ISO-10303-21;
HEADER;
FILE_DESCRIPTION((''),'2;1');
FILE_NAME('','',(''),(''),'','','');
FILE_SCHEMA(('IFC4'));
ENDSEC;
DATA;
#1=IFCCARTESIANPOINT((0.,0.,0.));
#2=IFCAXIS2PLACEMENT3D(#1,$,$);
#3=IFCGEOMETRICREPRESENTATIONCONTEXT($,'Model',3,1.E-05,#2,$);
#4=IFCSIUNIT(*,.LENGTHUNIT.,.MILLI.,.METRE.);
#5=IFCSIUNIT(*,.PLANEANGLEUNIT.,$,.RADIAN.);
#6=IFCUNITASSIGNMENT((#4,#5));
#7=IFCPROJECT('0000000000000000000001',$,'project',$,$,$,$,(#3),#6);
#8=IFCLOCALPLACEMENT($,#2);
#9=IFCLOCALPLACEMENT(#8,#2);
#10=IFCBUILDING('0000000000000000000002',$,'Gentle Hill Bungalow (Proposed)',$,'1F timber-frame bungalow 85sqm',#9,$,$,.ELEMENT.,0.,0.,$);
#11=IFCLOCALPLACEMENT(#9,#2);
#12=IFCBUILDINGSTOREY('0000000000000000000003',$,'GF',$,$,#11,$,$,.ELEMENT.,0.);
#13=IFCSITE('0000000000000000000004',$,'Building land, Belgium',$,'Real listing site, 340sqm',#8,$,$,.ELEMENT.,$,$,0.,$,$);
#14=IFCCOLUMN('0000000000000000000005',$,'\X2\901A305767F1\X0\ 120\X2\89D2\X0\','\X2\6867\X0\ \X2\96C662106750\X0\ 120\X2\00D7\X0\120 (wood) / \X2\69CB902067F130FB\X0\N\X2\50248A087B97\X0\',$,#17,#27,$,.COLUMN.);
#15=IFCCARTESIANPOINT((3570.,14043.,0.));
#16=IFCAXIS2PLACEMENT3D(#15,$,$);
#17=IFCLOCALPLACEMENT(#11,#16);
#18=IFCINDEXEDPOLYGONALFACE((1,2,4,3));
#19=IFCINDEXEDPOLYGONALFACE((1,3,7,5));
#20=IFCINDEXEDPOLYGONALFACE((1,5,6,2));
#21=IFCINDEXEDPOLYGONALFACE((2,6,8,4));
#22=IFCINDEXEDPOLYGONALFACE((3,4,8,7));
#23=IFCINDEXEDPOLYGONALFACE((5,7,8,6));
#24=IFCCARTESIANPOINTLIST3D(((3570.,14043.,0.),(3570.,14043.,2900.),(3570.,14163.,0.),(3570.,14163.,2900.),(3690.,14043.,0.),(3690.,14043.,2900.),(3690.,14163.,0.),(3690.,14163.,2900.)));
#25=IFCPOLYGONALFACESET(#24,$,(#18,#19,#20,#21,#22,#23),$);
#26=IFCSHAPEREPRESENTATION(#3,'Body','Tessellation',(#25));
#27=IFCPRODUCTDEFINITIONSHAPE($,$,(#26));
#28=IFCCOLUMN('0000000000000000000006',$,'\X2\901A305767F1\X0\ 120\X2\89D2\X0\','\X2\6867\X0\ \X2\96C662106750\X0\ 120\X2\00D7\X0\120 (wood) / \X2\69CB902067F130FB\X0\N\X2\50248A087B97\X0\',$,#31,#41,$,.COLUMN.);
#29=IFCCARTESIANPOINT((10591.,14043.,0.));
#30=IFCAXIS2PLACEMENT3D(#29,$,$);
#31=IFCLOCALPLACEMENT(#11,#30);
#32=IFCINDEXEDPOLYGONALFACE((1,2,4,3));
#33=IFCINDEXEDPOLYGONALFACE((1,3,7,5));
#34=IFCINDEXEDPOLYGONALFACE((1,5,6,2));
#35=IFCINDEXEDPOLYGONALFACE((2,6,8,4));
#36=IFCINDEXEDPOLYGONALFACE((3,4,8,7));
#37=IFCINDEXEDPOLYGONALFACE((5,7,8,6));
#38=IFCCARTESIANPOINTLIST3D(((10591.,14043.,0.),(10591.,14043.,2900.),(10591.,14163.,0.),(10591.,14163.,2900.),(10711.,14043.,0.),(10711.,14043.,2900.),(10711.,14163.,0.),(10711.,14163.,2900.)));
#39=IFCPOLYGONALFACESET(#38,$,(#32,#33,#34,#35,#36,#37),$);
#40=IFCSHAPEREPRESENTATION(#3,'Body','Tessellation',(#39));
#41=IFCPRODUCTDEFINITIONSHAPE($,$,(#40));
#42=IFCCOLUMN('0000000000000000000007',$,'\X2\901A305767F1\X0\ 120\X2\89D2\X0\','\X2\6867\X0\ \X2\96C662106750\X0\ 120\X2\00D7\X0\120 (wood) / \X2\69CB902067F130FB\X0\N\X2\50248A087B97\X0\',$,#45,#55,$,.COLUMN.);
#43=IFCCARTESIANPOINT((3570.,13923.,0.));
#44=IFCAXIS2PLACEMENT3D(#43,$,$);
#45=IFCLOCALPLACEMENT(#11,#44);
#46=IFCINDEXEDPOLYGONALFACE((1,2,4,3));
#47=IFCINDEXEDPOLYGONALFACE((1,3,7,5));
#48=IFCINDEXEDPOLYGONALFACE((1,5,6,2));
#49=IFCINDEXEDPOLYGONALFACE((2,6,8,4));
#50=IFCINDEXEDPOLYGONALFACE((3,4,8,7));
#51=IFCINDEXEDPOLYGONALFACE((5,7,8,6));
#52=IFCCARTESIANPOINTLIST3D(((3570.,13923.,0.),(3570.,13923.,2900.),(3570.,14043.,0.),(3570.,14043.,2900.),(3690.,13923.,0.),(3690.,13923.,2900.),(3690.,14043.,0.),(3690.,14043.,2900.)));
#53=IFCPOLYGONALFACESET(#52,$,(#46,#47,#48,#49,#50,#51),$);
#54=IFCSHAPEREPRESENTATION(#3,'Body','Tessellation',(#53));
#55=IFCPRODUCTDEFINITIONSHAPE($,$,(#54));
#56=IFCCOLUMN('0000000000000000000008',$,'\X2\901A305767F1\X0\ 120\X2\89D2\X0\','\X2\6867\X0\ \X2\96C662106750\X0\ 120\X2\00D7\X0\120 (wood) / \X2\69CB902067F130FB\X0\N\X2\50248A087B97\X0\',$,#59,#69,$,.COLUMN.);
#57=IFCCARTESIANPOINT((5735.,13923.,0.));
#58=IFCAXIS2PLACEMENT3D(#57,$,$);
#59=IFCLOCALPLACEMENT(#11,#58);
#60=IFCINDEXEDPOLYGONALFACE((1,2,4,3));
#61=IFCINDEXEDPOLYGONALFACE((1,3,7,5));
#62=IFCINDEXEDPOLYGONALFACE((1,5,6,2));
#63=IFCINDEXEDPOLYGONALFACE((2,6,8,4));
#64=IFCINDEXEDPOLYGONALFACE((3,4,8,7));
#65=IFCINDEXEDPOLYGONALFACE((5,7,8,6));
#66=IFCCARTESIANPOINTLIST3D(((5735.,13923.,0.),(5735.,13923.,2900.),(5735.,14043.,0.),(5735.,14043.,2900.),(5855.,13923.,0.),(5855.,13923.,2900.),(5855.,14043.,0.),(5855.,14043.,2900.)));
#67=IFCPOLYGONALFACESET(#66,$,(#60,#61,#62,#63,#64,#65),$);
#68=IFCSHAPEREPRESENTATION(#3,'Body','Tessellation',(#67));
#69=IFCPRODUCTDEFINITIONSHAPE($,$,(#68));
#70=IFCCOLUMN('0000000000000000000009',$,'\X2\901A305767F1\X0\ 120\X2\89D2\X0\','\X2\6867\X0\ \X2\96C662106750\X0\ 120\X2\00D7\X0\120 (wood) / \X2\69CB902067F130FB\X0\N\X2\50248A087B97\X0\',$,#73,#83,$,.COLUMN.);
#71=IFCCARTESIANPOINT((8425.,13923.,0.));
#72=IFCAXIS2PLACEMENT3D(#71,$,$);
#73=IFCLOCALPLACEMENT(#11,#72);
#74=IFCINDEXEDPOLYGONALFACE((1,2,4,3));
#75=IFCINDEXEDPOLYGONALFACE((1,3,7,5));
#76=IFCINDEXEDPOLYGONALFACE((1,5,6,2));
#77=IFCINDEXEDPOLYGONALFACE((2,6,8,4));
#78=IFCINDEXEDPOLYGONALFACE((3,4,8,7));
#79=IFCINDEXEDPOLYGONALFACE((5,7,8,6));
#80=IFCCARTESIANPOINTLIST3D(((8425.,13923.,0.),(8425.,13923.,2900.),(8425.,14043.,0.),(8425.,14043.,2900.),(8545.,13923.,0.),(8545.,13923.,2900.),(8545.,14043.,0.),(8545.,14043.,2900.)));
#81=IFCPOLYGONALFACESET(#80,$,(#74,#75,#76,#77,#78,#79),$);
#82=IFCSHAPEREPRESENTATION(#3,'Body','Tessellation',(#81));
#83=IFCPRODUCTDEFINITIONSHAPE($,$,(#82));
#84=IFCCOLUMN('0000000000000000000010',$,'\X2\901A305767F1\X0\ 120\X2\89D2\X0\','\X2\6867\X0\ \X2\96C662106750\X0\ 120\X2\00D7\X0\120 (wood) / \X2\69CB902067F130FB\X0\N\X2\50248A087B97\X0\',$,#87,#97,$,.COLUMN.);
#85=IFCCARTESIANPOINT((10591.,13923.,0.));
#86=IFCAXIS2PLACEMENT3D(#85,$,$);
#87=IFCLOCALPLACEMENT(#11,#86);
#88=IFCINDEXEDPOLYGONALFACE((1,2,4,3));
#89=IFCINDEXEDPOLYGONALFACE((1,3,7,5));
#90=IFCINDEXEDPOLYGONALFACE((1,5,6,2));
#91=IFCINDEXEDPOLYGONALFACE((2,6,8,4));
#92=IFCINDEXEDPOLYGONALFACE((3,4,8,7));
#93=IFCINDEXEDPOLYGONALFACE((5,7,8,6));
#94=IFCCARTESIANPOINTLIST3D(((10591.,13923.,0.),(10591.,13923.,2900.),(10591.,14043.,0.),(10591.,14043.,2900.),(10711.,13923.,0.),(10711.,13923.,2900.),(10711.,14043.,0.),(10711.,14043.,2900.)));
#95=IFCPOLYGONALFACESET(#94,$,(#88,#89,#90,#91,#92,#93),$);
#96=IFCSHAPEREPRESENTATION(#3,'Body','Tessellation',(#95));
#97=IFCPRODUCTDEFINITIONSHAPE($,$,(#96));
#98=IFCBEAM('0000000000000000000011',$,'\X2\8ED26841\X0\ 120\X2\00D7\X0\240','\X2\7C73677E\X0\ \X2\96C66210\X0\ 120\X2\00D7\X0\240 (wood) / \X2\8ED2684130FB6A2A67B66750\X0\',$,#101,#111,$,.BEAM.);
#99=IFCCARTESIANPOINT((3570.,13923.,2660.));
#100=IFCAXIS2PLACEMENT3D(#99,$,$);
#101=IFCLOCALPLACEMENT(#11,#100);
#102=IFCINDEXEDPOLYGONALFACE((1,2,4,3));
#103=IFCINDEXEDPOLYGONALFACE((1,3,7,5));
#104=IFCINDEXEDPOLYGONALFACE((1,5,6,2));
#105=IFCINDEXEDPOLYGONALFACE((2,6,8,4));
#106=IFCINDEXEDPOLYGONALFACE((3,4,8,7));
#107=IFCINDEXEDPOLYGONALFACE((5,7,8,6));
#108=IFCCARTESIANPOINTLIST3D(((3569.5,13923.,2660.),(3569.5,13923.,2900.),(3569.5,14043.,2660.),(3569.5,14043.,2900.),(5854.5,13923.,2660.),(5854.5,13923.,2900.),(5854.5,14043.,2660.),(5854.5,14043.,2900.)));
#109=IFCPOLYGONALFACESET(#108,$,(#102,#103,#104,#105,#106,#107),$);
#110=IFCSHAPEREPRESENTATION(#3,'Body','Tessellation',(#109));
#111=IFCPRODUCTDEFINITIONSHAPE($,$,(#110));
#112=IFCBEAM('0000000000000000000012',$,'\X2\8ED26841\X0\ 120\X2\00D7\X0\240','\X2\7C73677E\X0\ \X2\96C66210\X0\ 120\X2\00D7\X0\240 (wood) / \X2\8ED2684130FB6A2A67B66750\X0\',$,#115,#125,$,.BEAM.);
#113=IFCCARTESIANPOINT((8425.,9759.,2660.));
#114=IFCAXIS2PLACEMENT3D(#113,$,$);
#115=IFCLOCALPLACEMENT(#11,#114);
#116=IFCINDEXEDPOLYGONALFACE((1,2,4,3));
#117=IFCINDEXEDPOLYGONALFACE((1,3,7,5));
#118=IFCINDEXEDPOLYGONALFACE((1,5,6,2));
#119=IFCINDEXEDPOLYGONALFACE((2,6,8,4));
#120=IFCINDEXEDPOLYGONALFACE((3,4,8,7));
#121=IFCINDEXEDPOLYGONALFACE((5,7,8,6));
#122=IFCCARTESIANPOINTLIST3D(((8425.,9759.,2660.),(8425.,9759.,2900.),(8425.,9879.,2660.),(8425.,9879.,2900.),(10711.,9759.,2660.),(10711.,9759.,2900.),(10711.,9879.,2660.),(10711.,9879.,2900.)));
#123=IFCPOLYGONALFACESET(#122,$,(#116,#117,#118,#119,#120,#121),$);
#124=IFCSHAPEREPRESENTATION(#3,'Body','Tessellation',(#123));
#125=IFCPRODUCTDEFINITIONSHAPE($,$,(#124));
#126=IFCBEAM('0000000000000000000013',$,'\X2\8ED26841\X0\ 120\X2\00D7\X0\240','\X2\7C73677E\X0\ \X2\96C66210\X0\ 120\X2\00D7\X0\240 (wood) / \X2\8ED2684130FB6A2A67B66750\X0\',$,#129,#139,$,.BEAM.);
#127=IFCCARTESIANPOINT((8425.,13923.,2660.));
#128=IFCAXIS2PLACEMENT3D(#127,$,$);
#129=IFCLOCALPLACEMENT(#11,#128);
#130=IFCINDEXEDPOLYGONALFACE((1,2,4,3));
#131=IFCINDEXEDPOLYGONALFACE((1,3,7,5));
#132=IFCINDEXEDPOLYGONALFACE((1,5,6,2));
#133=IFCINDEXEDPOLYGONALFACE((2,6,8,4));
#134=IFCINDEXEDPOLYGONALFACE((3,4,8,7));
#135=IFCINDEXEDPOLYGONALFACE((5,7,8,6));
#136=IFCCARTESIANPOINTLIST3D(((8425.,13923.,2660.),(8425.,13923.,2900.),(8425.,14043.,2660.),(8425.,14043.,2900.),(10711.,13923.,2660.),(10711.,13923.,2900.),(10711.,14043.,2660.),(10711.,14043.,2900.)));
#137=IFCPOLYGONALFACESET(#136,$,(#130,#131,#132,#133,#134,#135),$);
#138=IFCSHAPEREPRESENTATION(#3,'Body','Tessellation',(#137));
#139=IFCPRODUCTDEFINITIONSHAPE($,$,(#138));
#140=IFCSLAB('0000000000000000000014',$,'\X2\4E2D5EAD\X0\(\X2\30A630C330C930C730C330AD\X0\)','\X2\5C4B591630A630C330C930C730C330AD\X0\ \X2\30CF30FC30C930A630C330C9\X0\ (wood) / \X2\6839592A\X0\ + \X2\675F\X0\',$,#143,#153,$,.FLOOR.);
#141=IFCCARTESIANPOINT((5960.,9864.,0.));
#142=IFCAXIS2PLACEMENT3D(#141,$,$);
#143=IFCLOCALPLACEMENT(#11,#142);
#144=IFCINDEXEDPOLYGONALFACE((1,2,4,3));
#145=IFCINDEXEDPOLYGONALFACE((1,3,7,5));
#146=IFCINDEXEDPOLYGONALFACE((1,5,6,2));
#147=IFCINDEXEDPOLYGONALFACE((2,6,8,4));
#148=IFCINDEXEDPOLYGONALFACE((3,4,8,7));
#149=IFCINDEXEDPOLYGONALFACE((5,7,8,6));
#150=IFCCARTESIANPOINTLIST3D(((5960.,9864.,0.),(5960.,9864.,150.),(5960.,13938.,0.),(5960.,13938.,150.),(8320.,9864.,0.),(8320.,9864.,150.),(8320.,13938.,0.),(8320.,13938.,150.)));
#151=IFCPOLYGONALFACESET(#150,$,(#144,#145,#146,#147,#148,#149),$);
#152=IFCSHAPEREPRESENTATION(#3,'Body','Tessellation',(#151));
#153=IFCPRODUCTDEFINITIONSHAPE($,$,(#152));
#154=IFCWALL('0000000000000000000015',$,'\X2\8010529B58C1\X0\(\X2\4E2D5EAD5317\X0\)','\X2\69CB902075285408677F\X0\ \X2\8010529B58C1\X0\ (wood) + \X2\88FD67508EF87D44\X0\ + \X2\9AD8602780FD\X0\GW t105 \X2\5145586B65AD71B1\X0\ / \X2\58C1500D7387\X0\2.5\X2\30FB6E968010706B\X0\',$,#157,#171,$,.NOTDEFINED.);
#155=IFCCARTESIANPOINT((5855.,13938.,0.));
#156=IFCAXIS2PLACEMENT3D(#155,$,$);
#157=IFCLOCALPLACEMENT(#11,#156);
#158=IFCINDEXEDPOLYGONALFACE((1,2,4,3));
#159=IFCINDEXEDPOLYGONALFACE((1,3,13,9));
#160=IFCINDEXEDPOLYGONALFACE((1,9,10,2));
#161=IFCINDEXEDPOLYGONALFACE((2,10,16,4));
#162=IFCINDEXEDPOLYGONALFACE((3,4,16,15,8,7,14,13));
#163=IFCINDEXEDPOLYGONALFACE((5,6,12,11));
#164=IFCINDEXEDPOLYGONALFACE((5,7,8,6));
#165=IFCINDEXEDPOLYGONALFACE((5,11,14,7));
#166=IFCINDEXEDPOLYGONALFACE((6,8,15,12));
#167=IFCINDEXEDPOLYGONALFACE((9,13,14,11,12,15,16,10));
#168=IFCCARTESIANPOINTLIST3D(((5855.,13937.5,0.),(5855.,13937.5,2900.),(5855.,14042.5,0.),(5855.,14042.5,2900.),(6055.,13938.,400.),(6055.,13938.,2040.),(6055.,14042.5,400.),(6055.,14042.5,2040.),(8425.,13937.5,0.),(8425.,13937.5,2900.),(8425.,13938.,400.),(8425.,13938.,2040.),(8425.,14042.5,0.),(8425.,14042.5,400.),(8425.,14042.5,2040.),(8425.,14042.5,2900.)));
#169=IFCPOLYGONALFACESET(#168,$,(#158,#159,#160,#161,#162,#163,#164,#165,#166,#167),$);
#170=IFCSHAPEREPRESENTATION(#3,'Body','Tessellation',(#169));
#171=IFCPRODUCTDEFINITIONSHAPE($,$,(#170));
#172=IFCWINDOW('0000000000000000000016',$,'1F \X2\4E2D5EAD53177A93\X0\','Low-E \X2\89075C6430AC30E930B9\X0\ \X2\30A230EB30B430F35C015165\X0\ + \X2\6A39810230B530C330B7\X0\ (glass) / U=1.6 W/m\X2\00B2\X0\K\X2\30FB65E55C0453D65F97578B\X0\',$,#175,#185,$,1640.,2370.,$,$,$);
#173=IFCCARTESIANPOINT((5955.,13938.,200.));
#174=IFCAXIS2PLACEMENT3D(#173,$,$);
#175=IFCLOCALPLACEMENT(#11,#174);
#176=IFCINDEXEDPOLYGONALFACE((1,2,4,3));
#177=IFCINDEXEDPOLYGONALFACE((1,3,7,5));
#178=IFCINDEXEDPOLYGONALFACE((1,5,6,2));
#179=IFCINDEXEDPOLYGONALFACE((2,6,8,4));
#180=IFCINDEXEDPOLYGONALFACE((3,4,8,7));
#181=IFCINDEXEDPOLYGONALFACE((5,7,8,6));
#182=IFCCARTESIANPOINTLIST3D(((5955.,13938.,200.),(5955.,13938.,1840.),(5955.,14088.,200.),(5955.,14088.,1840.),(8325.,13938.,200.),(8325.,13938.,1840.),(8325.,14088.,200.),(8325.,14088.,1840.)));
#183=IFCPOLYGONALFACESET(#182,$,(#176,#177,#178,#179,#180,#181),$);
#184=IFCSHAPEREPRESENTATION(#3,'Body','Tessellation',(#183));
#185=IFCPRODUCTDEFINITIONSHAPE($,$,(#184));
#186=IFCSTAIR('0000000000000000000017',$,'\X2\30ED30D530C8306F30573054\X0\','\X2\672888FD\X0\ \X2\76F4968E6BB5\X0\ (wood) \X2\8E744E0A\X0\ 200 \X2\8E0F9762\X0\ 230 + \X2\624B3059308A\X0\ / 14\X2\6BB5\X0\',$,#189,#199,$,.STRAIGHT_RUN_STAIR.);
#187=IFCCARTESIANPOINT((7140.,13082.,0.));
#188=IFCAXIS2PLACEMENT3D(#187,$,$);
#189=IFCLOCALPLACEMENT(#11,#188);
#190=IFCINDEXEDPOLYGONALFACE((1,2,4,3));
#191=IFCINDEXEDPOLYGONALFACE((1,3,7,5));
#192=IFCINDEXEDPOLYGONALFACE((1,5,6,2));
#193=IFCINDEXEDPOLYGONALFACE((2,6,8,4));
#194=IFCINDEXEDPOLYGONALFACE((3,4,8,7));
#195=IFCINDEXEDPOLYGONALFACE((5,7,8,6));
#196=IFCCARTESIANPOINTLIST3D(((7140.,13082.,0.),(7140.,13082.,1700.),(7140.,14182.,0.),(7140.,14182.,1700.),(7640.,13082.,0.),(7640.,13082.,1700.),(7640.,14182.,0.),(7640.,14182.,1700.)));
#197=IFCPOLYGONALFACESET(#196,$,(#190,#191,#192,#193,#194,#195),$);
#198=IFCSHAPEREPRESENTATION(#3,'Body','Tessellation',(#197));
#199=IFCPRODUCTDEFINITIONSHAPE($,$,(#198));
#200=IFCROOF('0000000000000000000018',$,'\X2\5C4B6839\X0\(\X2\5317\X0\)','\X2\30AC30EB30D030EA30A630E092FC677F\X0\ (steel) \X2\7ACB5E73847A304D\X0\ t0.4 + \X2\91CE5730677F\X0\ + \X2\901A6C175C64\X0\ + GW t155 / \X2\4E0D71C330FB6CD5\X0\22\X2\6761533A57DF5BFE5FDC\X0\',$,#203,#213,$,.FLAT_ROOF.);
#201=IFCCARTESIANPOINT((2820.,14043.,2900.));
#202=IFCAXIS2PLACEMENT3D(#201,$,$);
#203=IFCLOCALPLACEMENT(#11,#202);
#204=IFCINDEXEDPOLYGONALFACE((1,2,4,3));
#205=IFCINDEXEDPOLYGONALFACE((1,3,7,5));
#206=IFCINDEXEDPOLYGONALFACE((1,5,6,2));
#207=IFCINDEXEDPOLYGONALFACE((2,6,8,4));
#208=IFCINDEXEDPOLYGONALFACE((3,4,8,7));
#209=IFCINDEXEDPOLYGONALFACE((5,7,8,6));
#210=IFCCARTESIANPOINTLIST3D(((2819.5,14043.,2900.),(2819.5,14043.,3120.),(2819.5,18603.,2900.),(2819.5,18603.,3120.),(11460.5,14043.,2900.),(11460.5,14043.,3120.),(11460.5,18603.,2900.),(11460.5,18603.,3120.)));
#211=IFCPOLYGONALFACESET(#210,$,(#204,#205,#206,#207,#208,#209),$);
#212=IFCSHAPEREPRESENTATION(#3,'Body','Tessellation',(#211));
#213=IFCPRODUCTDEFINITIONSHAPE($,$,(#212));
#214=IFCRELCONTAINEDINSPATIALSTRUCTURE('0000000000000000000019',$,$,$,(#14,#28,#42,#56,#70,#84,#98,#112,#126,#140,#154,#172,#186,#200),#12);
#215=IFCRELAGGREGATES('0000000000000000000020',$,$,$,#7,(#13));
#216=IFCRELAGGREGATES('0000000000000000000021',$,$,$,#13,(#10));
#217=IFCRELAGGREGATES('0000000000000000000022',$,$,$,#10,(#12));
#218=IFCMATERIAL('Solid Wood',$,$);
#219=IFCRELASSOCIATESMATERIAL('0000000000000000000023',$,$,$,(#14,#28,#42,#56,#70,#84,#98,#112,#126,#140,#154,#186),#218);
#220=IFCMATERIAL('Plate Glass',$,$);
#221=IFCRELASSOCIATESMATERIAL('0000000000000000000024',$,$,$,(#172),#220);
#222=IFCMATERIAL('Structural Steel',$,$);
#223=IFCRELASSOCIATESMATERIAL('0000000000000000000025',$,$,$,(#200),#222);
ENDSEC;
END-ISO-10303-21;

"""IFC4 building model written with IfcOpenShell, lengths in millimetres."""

from ifc_helpers import new_model, si_unit, frame, frame_2d, origin, place, context, project, spatial, rectangle, extrude, material, element, fill, save


model = new_model("IFC4")

# Units and contexts
model_context = context("Model", 3, precision=1e-05, world=origin())
ifc_project = project(units=[si_unit("LENGTHUNIT", "METRE", prefix="MILLI"), si_unit("PLANEANGLEUNIT", "RADIAN")], contexts=[model_context])

# Site, building, storey
site_placement = place(None, origin())
site = spatial("IfcSite", under=ifc_project, at=site_placement, Name="Building land, Belgium", ObjectType="Real listing site, 340sqm", CompositionType="ELEMENT", RefElevation=0.0)
building_placement = place(site_placement, origin())
building = spatial("IfcBuilding", under=site, at=building_placement, Name="Gentle Hill Bungalow (Proposed)", ObjectType="1F timber-frame bungalow 85sqm", CompositionType="ELEMENT", ElevationOfRefHeight=0.0, ElevationOfTerrain=0.0)
storey_placement = place(building_placement, origin())
storey = spatial("IfcBuildingStorey", under=building, at=storey_placement, Name="GF", CompositionType="ELEMENT", Elevation=0.0)

# Columns
ifc_material_1 = material(Name="Solid Wood")
column_1_placement = place(storey_placement, frame((3570.0, 14043.0, 0.0)))
element("IfcColumn", 1, at=column_1_placement, inside=storey, material=ifc_material_1, Name="通し柱 120角", Description="桧 集成材 120×120 (wood) / 構造柱・N値計算", PredefinedType="COLUMN", context=model_context, shape_type="SweptSolid", body=[
    extrude(rectangle(XDim=120.0, YDim=120.0, at=frame_2d((60.0, 60.0))), frame((3570.0, 14043.0, 0.0)), (0.0, 0.0, 1.0), 2900.0),
])
column_2_placement = place(storey_placement, frame((10591.0, 14043.0, 0.0)))
element("IfcColumn", 2, at=column_2_placement, inside=storey, material=ifc_material_1, Name="通し柱 120角", Description="桧 集成材 120×120 (wood) / 構造柱・N値計算", PredefinedType="COLUMN", context=model_context, shape_type="SweptSolid", body=[
    extrude(rectangle(XDim=120.0, YDim=120.0, at=frame_2d((60.0, 60.0))), frame((10591.0, 14043.0, 0.0)), (0.0, 0.0, 1.0), 2900.0),
])
column_3_placement = place(storey_placement, frame((3570.0, 13923.0, 0.0)))
element("IfcColumn", 3, at=column_3_placement, inside=storey, material=ifc_material_1, Name="通し柱 120角", Description="桧 集成材 120×120 (wood) / 構造柱・N値計算", PredefinedType="COLUMN", context=model_context, shape_type="SweptSolid", body=[
    extrude(rectangle(XDim=120.0, YDim=120.0, at=frame_2d((60.0, 60.0))), frame((3570.0, 13923.0, 0.0)), (0.0, 0.0, 1.0), 2900.0),
])
column_4_placement = place(storey_placement, frame((5735.0, 13923.0, 0.0)))
element("IfcColumn", 4, at=column_4_placement, inside=storey, material=ifc_material_1, Name="通し柱 120角", Description="桧 集成材 120×120 (wood) / 構造柱・N値計算", PredefinedType="COLUMN", context=model_context, shape_type="SweptSolid", body=[
    extrude(rectangle(XDim=120.0, YDim=120.0, at=frame_2d((60.0, 60.0))), frame((5735.0, 13923.0, 0.0)), (0.0, 0.0, 1.0), 2900.0),
])
column_5_placement = place(storey_placement, frame((8425.0, 13923.0, 0.0)))
element("IfcColumn", 5, at=column_5_placement, inside=storey, material=ifc_material_1, Name="通し柱 120角", Description="桧 集成材 120×120 (wood) / 構造柱・N値計算", PredefinedType="COLUMN", context=model_context, shape_type="SweptSolid", body=[
    extrude(rectangle(XDim=120.0, YDim=120.0, at=frame_2d((60.0, 60.0))), frame((8425.0, 13923.0, 0.0)), (0.0, 0.0, 1.0), 2900.0),
])
column_6_placement = place(storey_placement, frame((10591.0, 13923.0, 0.0)))
element("IfcColumn", 6, at=column_6_placement, inside=storey, material=ifc_material_1, Name="通し柱 120角", Description="桧 集成材 120×120 (wood) / 構造柱・N値計算", PredefinedType="COLUMN", context=model_context, shape_type="SweptSolid", body=[
    extrude(rectangle(XDim=120.0, YDim=120.0, at=frame_2d((60.0, 60.0))), frame((10591.0, 13923.0, 0.0)), (0.0, 0.0, 1.0), 2900.0),
])

# Beams
beam_1_placement = place(storey_placement, frame((3570.0, 13923.0, 2660.0)))
element("IfcBeam", 7, at=beam_1_placement, inside=storey, material=ifc_material_1, Name="軒桁 120×240", Description="米松 集成 120×240 (wood) / 軒桁・横架材", PredefinedType="BEAM", context=model_context, shape_type="SweptSolid", body=[
    extrude(rectangle(XDim=2285.0, YDim=120.0, at=frame_2d((1142.0, 60.0))), frame((3570.0, 13923.0, 2660.0)), (0.0, 0.0, 1.0), 240.0),
])
beam_2_placement = place(storey_placement, frame((8425.0, 9759.0, 2660.0)))
element("IfcBeam", 8, at=beam_2_placement, inside=storey, material=ifc_material_1, Name="軒桁 120×240", Description="米松 集成 120×240 (wood) / 軒桁・横架材", PredefinedType="BEAM", context=model_context, shape_type="SweptSolid", body=[
    extrude(rectangle(XDim=2286.0, YDim=120.0, at=frame_2d((1143.0, 60.0))), frame((8425.0, 9759.0, 2660.0)), (0.0, 0.0, 1.0), 240.0),
])
beam_3_placement = place(storey_placement, frame((8425.0, 13923.0, 2660.0)))
element("IfcBeam", 9, at=beam_3_placement, inside=storey, material=ifc_material_1, Name="軒桁 120×240", Description="米松 集成 120×240 (wood) / 軒桁・横架材", PredefinedType="BEAM", context=model_context, shape_type="SweptSolid", body=[
    extrude(rectangle(XDim=2286.0, YDim=120.0, at=frame_2d((1143.0, 60.0))), frame((8425.0, 13923.0, 2660.0)), (0.0, 0.0, 1.0), 240.0),
])

# Slab
slab_1_placement = place(storey_placement, frame((5960.0, 9864.0, 0.0)))
element("IfcSlab", 10, at=slab_1_placement, inside=storey, material=ifc_material_1, Name="中庭(ウッドデッキ)", Description="屋外ウッドデッキ ハードウッド (wood) / 根太 + 束", PredefinedType="FLOOR", context=model_context, shape_type="SweptSolid", body=[
    extrude(rectangle(XDim=2360.0, YDim=4074.0, at=frame_2d((1180.0, 2037.0))), frame((5960.0, 9864.0, 0.0)), (0.0, 0.0, 1.0), 150.0),
])

# Wall, opening, window
wall_placement = place(storey_placement, frame((5855.0, 13938.0, 0.0)))
wall = element("IfcWall", 11, at=wall_placement, inside=storey, material=ifc_material_1, Name="耐力壁(中庭北)", Description="構造用合板 耐力壁 (wood) + 製材軸組 + 高性能GW t105 充填断熱 / 壁倍率2.5・準耐火", PredefinedType="NOTDEFINED", context=model_context, shape_type="SweptSolid", body=[
    extrude(rectangle(XDim=2570.0, YDim=105.0, at=frame_2d((1285.0, 52.0))), frame((5855.0, 13938.0, 0.0)), (0.0, 0.0, 1.0), 2900.0),
])
opening_placement = place(storey_placement, frame((5955.0, 13938.0, 200.0)))
opening = element("IfcOpeningElement", 12, at=opening_placement, cuts=wall, PredefinedType="NOTDEFINED", context=model_context, shape_type="SweptSolid", body=[
    extrude(rectangle(XDim=2370.0, YDim=150.0, at=frame_2d((1185.0, 75.0))), frame((5955.0, 13938.0, 200.0)), (0.0, 0.0, 1.0), 1640.0),
])
ifc_material_2 = material(Name="Plate Glass")
window_placement = place(storey_placement, frame((5955.0, 13938.0, 200.0)))
window = element("IfcWindow", 13, at=window_placement, inside=storey, material=ifc_material_2, Name="1F 中庭北窓", Description="Low-E 複層ガラス アルゴン封入 + 樹脂サッシ (glass) / U=1.6 W/m²K・日射取得型", OverallHeight=1640.0, OverallWidth=2370.0, context=model_context, shape_type="SweptSolid", body=[
    extrude(rectangle(XDim=2370.0, YDim=150.0, at=frame_2d((1185.0, 75.0))), frame((5955.0, 13938.0, 200.0)), (0.0, 0.0, 1.0), 1640.0),
])
fill(opening, window)

# Stair
stair_placement = place(storey_placement, frame((7140.0, 13082.0, 0.0)))
element("IfcStair", 14, at=stair_placement, inside=storey, material=ifc_material_1, Name="ロフトはしご", Description="木製 直階段 (wood) 蹴上 200 踏面 230 + 手すり / 14段", PredefinedType="STRAIGHT_RUN_STAIR", context=model_context, shape_type="SweptSolid", body=[
    extrude(rectangle(XDim=500.0, YDim=1100.0, at=frame_2d((250.0, 550.0))), frame((7140.0, 13082.0, 0.0)), (0.0, 0.0, 1.0), 1700.0),
])

# Roof
ifc_material_3 = material(Name="Structural Steel")
roof_placement = place(storey_placement, frame((2820.0, 14043.0, 2900.0)))
element("IfcRoof", 15, at=roof_placement, inside=storey, material=ifc_material_3, Name="屋根(北)", Description="ガルバリウム鋼板 (steel) 立平葺き t0.4 + 野地板 + 通気層 + GW t155 / 不燃・法22条区域対応", PredefinedType="FLAT_ROOF", context=model_context, shape_type="SweptSolid", body=[
    extrude(rectangle(XDim=8641.0, YDim=4560.0, at=frame_2d((4320.0, 2280.0))), frame((2820.0, 14043.0, 2900.0)), (0.0, 0.0, 1.0), 220.0),
])

save(model, "model.ifc")
